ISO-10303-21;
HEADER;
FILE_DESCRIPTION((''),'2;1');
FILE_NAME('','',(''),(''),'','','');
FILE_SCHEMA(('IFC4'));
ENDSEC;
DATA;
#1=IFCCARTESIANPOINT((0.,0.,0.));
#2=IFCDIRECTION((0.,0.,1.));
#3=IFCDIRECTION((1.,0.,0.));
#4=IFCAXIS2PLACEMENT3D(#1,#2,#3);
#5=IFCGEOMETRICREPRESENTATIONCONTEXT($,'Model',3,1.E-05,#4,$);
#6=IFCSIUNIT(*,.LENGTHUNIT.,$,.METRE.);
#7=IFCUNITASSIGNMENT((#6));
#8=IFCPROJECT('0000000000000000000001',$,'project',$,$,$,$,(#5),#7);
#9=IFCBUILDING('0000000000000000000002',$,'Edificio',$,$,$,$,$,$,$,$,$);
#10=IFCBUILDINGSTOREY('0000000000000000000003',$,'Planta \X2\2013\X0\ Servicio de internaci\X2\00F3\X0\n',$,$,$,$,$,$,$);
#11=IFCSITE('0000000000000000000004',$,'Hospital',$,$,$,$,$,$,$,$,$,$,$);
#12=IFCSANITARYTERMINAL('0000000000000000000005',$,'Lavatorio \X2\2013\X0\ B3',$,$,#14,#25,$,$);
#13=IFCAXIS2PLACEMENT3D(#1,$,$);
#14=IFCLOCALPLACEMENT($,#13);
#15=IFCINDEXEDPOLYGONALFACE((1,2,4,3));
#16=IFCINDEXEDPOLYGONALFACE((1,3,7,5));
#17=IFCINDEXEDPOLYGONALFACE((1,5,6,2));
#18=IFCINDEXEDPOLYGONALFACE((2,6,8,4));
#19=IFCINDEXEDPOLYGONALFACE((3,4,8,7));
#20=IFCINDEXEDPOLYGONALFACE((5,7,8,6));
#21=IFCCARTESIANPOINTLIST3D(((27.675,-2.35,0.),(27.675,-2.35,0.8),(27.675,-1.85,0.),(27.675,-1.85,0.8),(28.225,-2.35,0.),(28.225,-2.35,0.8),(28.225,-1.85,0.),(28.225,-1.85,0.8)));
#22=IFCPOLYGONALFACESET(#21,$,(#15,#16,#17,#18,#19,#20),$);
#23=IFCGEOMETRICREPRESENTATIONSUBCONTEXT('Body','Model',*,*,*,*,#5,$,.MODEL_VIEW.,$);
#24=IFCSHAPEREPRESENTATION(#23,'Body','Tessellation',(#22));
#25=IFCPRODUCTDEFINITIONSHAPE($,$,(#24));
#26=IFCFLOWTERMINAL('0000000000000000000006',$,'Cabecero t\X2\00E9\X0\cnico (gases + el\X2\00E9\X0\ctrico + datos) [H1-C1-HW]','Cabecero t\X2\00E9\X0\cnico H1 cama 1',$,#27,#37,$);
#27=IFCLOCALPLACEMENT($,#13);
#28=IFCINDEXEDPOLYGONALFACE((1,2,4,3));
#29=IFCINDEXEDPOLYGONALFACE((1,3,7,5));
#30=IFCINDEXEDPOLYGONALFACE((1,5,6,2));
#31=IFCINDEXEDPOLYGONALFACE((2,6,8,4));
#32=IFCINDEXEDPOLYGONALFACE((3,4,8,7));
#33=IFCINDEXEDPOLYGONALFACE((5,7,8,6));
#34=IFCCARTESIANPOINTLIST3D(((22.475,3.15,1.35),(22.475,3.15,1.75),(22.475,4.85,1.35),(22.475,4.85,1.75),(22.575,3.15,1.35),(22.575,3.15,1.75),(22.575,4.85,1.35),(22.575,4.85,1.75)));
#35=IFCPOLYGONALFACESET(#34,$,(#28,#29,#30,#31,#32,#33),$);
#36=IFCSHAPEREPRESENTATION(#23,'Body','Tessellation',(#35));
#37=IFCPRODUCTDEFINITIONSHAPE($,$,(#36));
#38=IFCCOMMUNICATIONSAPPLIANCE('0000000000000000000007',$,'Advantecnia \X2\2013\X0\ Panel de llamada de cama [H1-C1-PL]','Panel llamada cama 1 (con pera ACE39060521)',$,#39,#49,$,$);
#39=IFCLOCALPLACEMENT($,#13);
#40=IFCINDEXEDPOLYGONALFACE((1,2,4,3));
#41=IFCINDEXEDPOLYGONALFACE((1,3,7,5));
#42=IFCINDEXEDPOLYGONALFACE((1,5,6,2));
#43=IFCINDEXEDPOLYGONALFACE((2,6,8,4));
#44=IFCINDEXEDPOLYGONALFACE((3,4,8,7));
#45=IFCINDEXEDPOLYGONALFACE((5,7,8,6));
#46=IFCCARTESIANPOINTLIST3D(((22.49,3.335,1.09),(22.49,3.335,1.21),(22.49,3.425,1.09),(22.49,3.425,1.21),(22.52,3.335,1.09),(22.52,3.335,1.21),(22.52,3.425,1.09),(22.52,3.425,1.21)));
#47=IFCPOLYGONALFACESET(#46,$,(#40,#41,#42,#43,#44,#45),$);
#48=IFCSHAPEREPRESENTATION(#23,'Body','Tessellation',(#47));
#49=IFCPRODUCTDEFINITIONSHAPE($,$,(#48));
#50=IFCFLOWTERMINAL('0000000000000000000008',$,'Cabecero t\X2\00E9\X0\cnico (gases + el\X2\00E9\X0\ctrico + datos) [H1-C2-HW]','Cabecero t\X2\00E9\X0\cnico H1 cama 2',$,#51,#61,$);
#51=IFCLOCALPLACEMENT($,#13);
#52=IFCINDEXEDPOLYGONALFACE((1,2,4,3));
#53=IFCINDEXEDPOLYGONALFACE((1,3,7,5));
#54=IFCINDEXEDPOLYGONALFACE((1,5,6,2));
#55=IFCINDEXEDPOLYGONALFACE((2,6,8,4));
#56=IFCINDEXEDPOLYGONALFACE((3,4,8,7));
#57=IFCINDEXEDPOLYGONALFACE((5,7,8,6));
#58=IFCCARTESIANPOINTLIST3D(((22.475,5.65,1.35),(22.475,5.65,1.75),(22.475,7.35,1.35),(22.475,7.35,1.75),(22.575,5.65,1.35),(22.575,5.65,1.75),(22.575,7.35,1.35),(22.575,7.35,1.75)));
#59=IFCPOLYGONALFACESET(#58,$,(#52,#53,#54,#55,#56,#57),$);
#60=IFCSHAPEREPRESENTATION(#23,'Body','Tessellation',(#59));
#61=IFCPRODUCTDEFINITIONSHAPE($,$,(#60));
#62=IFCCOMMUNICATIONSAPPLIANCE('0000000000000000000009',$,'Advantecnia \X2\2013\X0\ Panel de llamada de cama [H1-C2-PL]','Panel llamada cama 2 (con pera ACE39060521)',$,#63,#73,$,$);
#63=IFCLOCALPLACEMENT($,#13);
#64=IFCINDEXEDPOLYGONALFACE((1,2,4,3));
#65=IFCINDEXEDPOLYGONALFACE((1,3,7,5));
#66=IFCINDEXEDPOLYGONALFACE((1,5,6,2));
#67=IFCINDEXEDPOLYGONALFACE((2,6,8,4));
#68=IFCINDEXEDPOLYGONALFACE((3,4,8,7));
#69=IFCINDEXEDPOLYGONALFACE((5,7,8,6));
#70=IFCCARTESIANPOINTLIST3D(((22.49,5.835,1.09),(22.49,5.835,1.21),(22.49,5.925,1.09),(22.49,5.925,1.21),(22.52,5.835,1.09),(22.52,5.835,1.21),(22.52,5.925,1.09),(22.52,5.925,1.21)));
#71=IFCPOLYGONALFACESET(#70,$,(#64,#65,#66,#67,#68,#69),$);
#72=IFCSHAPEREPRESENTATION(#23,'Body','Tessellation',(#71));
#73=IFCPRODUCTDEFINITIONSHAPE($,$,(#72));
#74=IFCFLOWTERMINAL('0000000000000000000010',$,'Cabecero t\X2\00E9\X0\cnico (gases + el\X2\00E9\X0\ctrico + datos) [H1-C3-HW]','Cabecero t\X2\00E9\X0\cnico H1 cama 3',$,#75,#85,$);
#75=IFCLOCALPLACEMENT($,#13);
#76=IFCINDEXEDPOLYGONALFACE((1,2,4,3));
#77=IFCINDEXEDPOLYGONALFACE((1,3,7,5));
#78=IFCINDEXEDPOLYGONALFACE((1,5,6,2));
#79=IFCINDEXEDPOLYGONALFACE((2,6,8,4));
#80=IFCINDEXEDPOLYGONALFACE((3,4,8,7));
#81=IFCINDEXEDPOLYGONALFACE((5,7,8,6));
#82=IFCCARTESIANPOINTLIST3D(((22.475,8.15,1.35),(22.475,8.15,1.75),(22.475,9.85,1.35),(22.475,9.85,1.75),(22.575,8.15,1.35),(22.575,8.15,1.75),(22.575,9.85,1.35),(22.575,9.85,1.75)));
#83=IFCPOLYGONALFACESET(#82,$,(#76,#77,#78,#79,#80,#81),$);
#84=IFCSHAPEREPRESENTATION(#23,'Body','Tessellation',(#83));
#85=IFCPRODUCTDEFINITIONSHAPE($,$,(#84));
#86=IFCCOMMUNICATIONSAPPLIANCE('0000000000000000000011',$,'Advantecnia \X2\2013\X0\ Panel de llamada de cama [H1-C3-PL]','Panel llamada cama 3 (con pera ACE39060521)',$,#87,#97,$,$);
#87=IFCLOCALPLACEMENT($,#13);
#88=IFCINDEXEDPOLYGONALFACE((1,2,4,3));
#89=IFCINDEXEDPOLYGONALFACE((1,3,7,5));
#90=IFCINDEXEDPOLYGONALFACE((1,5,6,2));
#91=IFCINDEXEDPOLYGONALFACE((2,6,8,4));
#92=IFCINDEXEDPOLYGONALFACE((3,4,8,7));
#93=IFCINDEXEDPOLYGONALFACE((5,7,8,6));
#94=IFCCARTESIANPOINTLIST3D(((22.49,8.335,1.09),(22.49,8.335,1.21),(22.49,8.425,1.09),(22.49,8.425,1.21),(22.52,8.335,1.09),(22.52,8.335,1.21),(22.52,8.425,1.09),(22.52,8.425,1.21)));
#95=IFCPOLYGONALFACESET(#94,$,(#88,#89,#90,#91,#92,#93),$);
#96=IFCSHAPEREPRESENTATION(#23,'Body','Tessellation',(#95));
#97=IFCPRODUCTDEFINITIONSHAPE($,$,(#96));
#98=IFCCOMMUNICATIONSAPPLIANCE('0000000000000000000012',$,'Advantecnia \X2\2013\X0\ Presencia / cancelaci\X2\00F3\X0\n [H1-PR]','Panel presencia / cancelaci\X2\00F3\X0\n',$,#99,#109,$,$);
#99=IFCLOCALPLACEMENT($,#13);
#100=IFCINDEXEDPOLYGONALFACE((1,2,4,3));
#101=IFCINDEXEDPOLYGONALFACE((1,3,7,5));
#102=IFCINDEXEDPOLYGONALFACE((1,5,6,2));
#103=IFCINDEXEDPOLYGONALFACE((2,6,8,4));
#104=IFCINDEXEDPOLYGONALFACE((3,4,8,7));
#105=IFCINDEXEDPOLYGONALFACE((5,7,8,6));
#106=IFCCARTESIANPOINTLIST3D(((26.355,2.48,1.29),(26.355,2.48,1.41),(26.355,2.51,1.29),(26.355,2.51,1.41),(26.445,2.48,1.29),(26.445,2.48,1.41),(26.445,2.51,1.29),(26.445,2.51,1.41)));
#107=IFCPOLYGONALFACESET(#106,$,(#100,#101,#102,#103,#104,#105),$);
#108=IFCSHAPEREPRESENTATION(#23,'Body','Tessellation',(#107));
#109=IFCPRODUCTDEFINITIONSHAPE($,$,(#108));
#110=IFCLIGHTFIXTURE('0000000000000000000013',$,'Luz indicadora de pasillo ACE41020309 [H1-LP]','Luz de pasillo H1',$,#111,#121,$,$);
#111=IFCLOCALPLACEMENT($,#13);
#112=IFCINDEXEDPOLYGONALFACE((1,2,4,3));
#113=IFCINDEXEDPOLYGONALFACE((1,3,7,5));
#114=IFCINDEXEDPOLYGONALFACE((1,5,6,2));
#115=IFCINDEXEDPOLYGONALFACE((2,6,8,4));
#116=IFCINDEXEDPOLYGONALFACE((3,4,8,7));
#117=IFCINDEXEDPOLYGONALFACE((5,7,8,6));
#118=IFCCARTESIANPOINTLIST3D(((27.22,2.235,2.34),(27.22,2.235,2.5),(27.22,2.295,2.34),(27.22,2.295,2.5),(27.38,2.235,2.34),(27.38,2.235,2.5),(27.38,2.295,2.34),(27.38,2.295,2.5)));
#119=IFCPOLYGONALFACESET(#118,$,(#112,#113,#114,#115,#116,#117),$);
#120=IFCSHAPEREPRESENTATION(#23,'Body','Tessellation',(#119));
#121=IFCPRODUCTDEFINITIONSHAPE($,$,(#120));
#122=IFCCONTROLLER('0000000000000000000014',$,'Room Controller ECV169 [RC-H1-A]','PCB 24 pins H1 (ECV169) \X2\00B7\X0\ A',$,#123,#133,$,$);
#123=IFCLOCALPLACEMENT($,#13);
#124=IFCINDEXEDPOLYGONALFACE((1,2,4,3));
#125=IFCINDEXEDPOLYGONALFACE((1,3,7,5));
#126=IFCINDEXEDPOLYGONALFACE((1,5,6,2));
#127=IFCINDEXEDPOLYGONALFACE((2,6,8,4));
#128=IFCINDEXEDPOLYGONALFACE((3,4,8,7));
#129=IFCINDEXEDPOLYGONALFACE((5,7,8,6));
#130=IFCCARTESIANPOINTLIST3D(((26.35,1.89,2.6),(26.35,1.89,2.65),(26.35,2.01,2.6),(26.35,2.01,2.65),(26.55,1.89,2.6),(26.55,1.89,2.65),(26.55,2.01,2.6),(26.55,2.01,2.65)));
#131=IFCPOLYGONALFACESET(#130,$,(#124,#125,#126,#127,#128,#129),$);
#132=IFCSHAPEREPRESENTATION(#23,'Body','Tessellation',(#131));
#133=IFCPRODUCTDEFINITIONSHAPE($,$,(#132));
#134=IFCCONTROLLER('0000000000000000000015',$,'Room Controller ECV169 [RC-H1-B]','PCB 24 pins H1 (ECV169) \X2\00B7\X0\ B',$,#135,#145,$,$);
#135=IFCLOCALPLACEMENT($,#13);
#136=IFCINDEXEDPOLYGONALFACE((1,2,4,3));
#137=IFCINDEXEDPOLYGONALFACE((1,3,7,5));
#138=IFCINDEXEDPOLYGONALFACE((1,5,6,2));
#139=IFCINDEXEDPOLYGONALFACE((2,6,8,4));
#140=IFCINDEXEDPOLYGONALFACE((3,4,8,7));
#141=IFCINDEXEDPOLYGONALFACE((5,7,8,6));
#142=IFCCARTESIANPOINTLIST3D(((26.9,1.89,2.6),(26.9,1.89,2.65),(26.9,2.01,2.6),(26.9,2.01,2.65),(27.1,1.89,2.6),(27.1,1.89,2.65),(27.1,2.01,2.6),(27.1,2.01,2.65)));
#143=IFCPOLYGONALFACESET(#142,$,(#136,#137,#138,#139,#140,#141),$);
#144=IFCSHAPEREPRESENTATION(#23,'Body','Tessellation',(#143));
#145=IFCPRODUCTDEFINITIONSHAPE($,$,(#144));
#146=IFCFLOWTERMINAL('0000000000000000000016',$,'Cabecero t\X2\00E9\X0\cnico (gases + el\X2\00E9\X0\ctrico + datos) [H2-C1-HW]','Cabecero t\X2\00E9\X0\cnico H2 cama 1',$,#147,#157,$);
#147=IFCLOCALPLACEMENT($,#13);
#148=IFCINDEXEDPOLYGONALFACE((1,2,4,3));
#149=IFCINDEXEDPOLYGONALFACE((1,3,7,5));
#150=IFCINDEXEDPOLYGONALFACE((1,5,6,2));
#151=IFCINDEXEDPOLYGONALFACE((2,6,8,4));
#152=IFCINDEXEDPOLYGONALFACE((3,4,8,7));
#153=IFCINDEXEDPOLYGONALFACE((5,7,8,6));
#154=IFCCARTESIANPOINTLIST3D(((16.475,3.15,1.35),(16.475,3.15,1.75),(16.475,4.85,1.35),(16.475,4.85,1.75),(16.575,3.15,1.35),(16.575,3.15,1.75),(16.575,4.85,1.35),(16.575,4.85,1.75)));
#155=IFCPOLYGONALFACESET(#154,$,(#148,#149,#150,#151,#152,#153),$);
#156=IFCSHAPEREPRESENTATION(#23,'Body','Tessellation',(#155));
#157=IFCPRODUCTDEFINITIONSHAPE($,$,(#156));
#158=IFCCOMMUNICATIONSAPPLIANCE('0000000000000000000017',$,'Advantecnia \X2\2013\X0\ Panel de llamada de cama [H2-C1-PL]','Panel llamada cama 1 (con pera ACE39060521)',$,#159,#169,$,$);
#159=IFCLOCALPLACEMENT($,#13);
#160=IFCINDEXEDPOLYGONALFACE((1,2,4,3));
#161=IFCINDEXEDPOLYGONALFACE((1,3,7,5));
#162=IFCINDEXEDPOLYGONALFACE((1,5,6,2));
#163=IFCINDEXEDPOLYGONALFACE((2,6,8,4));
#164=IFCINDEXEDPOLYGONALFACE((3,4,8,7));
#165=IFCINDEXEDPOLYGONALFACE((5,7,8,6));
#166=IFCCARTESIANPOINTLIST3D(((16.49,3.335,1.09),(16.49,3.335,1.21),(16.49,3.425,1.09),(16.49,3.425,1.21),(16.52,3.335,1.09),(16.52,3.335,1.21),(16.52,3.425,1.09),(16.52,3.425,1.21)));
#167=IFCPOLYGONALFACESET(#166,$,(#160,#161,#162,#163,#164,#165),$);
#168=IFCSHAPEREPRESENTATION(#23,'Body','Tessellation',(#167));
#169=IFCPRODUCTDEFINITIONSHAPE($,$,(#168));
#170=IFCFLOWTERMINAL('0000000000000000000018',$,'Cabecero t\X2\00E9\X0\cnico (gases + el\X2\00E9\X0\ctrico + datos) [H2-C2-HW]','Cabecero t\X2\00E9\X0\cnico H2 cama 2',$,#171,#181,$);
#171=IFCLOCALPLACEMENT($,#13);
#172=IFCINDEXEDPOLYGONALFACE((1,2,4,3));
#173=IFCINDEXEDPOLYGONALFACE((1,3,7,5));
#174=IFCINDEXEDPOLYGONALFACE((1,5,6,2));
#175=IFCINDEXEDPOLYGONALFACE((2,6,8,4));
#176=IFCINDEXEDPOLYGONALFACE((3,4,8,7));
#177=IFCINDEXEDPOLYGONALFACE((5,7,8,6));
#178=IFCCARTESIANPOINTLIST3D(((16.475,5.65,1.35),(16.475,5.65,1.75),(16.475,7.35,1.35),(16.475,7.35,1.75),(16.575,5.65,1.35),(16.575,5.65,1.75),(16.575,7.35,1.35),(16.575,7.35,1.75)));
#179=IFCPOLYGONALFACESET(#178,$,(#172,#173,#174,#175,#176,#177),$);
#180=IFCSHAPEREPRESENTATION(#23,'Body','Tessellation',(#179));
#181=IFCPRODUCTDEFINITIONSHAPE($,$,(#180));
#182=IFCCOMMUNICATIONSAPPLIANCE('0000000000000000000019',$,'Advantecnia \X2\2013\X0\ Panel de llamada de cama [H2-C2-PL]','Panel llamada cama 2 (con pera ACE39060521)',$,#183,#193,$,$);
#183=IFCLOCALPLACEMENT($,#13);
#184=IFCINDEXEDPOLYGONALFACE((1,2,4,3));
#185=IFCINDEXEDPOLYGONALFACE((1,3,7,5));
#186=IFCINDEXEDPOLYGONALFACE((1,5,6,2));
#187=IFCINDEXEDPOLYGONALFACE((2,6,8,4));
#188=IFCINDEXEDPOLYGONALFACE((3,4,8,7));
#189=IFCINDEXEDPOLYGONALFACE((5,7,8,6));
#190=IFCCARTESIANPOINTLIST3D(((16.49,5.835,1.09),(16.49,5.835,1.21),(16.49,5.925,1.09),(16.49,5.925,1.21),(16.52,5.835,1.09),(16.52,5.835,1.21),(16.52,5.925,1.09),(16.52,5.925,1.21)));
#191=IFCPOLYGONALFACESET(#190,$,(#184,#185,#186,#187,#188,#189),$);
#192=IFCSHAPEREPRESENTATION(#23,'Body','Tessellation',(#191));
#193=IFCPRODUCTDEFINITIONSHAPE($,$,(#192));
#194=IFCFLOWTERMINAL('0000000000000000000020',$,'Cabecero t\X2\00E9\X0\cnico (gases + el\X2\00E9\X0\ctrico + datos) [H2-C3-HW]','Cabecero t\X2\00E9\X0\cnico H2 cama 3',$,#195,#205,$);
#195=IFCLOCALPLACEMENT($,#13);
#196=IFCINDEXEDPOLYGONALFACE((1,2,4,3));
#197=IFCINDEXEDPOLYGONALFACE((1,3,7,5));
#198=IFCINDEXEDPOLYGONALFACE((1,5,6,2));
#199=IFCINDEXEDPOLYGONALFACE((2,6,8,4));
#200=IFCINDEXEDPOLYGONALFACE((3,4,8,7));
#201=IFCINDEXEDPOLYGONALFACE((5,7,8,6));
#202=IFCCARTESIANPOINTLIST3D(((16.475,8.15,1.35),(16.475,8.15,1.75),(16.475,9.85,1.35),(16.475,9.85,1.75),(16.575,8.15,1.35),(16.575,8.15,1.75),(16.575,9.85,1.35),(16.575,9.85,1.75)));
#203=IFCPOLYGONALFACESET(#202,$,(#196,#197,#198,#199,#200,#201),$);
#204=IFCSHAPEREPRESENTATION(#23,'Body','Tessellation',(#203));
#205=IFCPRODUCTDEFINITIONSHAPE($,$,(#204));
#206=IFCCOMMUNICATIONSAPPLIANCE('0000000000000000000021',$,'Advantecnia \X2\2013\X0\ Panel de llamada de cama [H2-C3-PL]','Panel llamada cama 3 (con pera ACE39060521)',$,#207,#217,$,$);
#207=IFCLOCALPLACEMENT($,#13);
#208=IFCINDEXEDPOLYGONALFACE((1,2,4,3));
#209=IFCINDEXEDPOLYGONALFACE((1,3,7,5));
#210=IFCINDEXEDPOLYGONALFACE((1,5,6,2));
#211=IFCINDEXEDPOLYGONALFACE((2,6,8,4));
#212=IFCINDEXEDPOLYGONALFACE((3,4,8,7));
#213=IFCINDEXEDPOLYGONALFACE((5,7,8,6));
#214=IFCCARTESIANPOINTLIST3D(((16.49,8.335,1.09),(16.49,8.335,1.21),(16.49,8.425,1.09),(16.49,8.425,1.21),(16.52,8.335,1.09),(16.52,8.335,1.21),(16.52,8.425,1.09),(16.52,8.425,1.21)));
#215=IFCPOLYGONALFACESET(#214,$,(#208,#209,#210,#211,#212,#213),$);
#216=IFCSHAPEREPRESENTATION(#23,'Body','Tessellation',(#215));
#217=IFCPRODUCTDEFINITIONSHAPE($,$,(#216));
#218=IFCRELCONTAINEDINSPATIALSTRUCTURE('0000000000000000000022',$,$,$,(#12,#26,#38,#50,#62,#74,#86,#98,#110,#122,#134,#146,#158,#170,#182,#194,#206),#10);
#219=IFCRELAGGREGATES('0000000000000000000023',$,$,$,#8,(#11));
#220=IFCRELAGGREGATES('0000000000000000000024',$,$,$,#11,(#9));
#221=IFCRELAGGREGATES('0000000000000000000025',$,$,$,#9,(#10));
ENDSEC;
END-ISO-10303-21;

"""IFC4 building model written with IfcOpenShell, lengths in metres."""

from ifc_helpers import new_model, si_unit, frame, origin_with_axes, context, subcontext, project, spatial, line, indexed_curve, outline, extrude, element, save


model = new_model("IFC4")

# Units and contexts
model_context = context("Model", 3, precision=1e-05, world=origin_with_axes())
body_context = subcontext(model_context, "Body", "Model", "MODEL_VIEW")
ifc_project = project(units=[si_unit("LENGTHUNIT", "METRE")], contexts=[model_context])

# Site, building, storey
site = spatial("IfcSite", under=ifc_project, Name="Hospital")
building = spatial("IfcBuilding", under=site, Name="Edificio")
storey = spatial("IfcBuildingStorey", under=building, Name="Planta – Servicio de internación")

# Sanitary terminal
element("IfcSanitaryTerminal", 1, inside=storey, Name="Lavatorio – B3", context=body_context, shape_type="SweptSolid", body=[
    extrude(outline(indexed_curve([(0.0, 0.0), (0.55, 0.0), (0.55, 0.5), (0.0, 0.5)], segments=[line(1, 2, 3, 4, 1)])), frame((27.675, -2.35, 0.0), z_axis=(0.0, 0.0, 1.0), x_axis=(1.0, 0.0, 0.0)), (0.0, 0.0, 1.0), 0.8),
])

# Flow terminal
element("IfcFlowTerminal", 2, inside=storey, Name="Cabecero técnico (gases + eléctrico + datos) [H1-C1-HW]", Description="Cabecero técnico H1 cama 1", context=body_context, shape_type="SweptSolid", body=[
    extrude(outline(indexed_curve([(0.0, 0.0), (0.1, 0.0), (0.1, 1.7), (0.0, 1.7)], segments=[line(1, 2, 3, 4, 1)])), frame((22.475, 3.15, 1.35), z_axis=(0.0, 0.0, 1.0), x_axis=(1.0, 0.0, 0.0)), (0.0, 0.0, 1.0), 0.4),
])

# Communications appliance
element("IfcCommunicationsAppliance", 3, inside=storey, Name="Advantecnia – Panel de llamada de cama [H1-C1-PL]", Description="Panel llamada cama 1 (con pera ACE39060521)", context=body_context, shape_type="SweptSolid", body=[
    extrude(outline(indexed_curve([(0.0, 0.0), (0.03, 0.0), (0.03, 0.09), (0.0, 0.09)], segments=[line(1, 2, 3, 4, 1)])), frame((22.49, 3.335, 1.09), z_axis=(0.0, 0.0, 1.0), x_axis=(1.0, 0.0, 0.0)), (0.0, 0.0, 1.0), 0.12),
])

# Flow terminal
element("IfcFlowTerminal", 4, inside=storey, Name="Cabecero técnico (gases + eléctrico + datos) [H1-C2-HW]", Description="Cabecero técnico H1 cama 2", context=body_context, shape_type="SweptSolid", body=[
    extrude(outline(indexed_curve([(0.0, 0.0), (0.1, 0.0), (0.1, 1.7), (0.0, 1.7)], segments=[line(1, 2, 3, 4, 1)])), frame((22.475, 5.65, 1.35), z_axis=(0.0, 0.0, 1.0), x_axis=(1.0, 0.0, 0.0)), (0.0, 0.0, 1.0), 0.4),
])

# Communications appliance
element("IfcCommunicationsAppliance", 5, inside=storey, Name="Advantecnia – Panel de llamada de cama [H1-C2-PL]", Description="Panel llamada cama 2 (con pera ACE39060521)", context=body_context, shape_type="SweptSolid", body=[
    extrude(outline(indexed_curve([(0.0, 0.0), (0.03, 0.0), (0.03, 0.09), (0.0, 0.09)], segments=[line(1, 2, 3, 4, 1)])), frame((22.49, 5.835, 1.09), z_axis=(0.0, 0.0, 1.0), x_axis=(1.0, 0.0, 0.0)), (0.0, 0.0, 1.0), 0.12),
])

# Flow terminal
element("IfcFlowTerminal", 6, inside=storey, Name="Cabecero técnico (gases + eléctrico + datos) [H1-C3-HW]", Description="Cabecero técnico H1 cama 3", context=body_context, shape_type="SweptSolid", body=[
    extrude(outline(indexed_curve([(0.0, 0.0), (0.1, 0.0), (0.1, 1.7), (0.0, 1.7)], segments=[line(1, 2, 3, 4, 1)])), frame((22.475, 8.15, 1.35), z_axis=(0.0, 0.0, 1.0), x_axis=(1.0, 0.0, 0.0)), (0.0, 0.0, 1.0), 0.4),
])

# Communications appliances
element("IfcCommunicationsAppliance", 7, inside=storey, Name="Advantecnia – Panel de llamada de cama [H1-C3-PL]", Description="Panel llamada cama 3 (con pera ACE39060521)", context=body_context, shape_type="SweptSolid", body=[
    extrude(outline(indexed_curve([(0.0, 0.0), (0.03, 0.0), (0.03, 0.09), (0.0, 0.09)], segments=[line(1, 2, 3, 4, 1)])), frame((22.49, 8.335, 1.09), z_axis=(0.0, 0.0, 1.0), x_axis=(1.0, 0.0, 0.0)), (0.0, 0.0, 1.0), 0.12),
])
element("IfcCommunicationsAppliance", 8, inside=storey, Name="Advantecnia – Presencia / cancelación [H1-PR]", Description="Panel presencia / cancelación", context=body_context, shape_type="SweptSolid", body=[
    extrude(outline(indexed_curve([(0.0, 0.0), (0.09, 0.0), (0.09, 0.03), (0.0, 0.03)], segments=[line(1, 2, 3, 4, 1)])), frame((26.355, 2.48, 1.29), z_axis=(0.0, 0.0, 1.0), x_axis=(1.0, 0.0, 0.0)), (0.0, 0.0, 1.0), 0.12),
])

# Light fixture
element("IfcLightFixture", 9, inside=storey, Name="Luz indicadora de pasillo ACE41020309 [H1-LP]", Description="Luz de pasillo H1", context=body_context, shape_type="SweptSolid", body=[
    extrude(outline(indexed_curve([(0.0, 0.0), (0.16, 0.0), (0.16, 0.06), (0.0, 0.06)], segments=[line(1, 2, 3, 4, 1)])), frame((27.22, 2.235, 2.34), z_axis=(0.0, 0.0, 1.0), x_axis=(1.0, 0.0, 0.0)), (0.0, 0.0, 1.0), 0.16),
])

# Controllers
element("IfcController", 10, inside=storey, Name="Room Controller ECV169 [RC-H1-A]", Description="PCB 24 pins H1 (ECV169) · A", context=body_context, shape_type="SweptSolid", body=[
    extrude(outline(indexed_curve([(0.0, 0.0), (0.2, 0.0), (0.2, 0.12), (0.0, 0.12)], segments=[line(1, 2, 3, 4, 1)])), frame((26.35, 1.89, 2.6), z_axis=(0.0, 0.0, 1.0), x_axis=(1.0, 0.0, 0.0)), (0.0, 0.0, 1.0), 0.05),
])
element("IfcController", 11, inside=storey, Name="Room Controller ECV169 [RC-H1-B]", Description="PCB 24 pins H1 (ECV169) · B", context=body_context, shape_type="SweptSolid", body=[
    extrude(outline(indexed_curve([(0.0, 0.0), (0.2, 0.0), (0.2, 0.12), (0.0, 0.12)], segments=[line(1, 2, 3, 4, 1)])), frame((26.9, 1.89, 2.6), z_axis=(0.0, 0.0, 1.0), x_axis=(1.0, 0.0, 0.0)), (0.0, 0.0, 1.0), 0.05),
])

# Flow terminal
element("IfcFlowTerminal", 12, inside=storey, Name="Cabecero técnico (gases + eléctrico + datos) [H2-C1-HW]", Description="Cabecero técnico H2 cama 1", context=body_context, shape_type="SweptSolid", body=[
    extrude(outline(indexed_curve([(0.0, 0.0), (0.1, 0.0), (0.1, 1.7), (0.0, 1.7)], segments=[line(1, 2, 3, 4, 1)])), frame((16.475, 3.15, 1.35), z_axis=(0.0, 0.0, 1.0), x_axis=(1.0, 0.0, 0.0)), (0.0, 0.0, 1.0), 0.4),
])

# Communications appliance
element("IfcCommunicationsAppliance", 13, inside=storey, Name="Advantecnia – Panel de llamada de cama [H2-C1-PL]", Description="Panel llamada cama 1 (con pera ACE39060521)", context=body_context, shape_type="SweptSolid", body=[
    extrude(outline(indexed_curve([(0.0, 0.0), (0.03, 0.0), (0.03, 0.09), (0.0, 0.09)], segments=[line(1, 2, 3, 4, 1)])), frame((16.49, 3.335, 1.09), z_axis=(0.0, 0.0, 1.0), x_axis=(1.0, 0.0, 0.0)), (0.0, 0.0, 1.0), 0.12),
])

# Flow terminal
element("IfcFlowTerminal", 14, inside=storey, Name="Cabecero técnico (gases + eléctrico + datos) [H2-C2-HW]", Description="Cabecero técnico H2 cama 2", context=body_context, shape_type="SweptSolid", body=[
    extrude(outline(indexed_curve([(0.0, 0.0), (0.1, 0.0), (0.1, 1.7), (0.0, 1.7)], segments=[line(1, 2, 3, 4, 1)])), frame((16.475, 5.65, 1.35), z_axis=(0.0, 0.0, 1.0), x_axis=(1.0, 0.0, 0.0)), (0.0, 0.0, 1.0), 0.4),
])

# Communications appliance
element("IfcCommunicationsAppliance", 15, inside=storey, Name="Advantecnia – Panel de llamada de cama [H2-C2-PL]", Description="Panel llamada cama 2 (con pera ACE39060521)", context=body_context, shape_type="SweptSolid", body=[
    extrude(outline(indexed_curve([(0.0, 0.0), (0.03, 0.0), (0.03, 0.09), (0.0, 0.09)], segments=[line(1, 2, 3, 4, 1)])), frame((16.49, 5.835, 1.09), z_axis=(0.0, 0.0, 1.0), x_axis=(1.0, 0.0, 0.0)), (0.0, 0.0, 1.0), 0.12),
])

# Flow terminal
element("IfcFlowTerminal", 16, inside=storey, Name="Cabecero técnico (gases + eléctrico + datos) [H2-C3-HW]", Description="Cabecero técnico H2 cama 3", context=body_context, shape_type="SweptSolid", body=[
    extrude(outline(indexed_curve([(0.0, 0.0), (0.1, 0.0), (0.1, 1.7), (0.0, 1.7)], segments=[line(1, 2, 3, 4, 1)])), frame((16.475, 8.15, 1.35), z_axis=(0.0, 0.0, 1.0), x_axis=(1.0, 0.0, 0.0)), (0.0, 0.0, 1.0), 0.4),
])

# Communications appliance
element("IfcCommunicationsAppliance", 17, inside=storey, Name="Advantecnia – Panel de llamada de cama [H2-C3-PL]", Description="Panel llamada cama 3 (con pera ACE39060521)", context=body_context, shape_type="SweptSolid", body=[
    extrude(outline(indexed_curve([(0.0, 0.0), (0.03, 0.0), (0.03, 0.09), (0.0, 0.09)], segments=[line(1, 2, 3, 4, 1)])), frame((16.49, 8.335, 1.09), z_axis=(0.0, 0.0, 1.0), x_axis=(1.0, 0.0, 0.0)), (0.0, 0.0, 1.0), 0.12),
])

save(model, "model.ifc")
